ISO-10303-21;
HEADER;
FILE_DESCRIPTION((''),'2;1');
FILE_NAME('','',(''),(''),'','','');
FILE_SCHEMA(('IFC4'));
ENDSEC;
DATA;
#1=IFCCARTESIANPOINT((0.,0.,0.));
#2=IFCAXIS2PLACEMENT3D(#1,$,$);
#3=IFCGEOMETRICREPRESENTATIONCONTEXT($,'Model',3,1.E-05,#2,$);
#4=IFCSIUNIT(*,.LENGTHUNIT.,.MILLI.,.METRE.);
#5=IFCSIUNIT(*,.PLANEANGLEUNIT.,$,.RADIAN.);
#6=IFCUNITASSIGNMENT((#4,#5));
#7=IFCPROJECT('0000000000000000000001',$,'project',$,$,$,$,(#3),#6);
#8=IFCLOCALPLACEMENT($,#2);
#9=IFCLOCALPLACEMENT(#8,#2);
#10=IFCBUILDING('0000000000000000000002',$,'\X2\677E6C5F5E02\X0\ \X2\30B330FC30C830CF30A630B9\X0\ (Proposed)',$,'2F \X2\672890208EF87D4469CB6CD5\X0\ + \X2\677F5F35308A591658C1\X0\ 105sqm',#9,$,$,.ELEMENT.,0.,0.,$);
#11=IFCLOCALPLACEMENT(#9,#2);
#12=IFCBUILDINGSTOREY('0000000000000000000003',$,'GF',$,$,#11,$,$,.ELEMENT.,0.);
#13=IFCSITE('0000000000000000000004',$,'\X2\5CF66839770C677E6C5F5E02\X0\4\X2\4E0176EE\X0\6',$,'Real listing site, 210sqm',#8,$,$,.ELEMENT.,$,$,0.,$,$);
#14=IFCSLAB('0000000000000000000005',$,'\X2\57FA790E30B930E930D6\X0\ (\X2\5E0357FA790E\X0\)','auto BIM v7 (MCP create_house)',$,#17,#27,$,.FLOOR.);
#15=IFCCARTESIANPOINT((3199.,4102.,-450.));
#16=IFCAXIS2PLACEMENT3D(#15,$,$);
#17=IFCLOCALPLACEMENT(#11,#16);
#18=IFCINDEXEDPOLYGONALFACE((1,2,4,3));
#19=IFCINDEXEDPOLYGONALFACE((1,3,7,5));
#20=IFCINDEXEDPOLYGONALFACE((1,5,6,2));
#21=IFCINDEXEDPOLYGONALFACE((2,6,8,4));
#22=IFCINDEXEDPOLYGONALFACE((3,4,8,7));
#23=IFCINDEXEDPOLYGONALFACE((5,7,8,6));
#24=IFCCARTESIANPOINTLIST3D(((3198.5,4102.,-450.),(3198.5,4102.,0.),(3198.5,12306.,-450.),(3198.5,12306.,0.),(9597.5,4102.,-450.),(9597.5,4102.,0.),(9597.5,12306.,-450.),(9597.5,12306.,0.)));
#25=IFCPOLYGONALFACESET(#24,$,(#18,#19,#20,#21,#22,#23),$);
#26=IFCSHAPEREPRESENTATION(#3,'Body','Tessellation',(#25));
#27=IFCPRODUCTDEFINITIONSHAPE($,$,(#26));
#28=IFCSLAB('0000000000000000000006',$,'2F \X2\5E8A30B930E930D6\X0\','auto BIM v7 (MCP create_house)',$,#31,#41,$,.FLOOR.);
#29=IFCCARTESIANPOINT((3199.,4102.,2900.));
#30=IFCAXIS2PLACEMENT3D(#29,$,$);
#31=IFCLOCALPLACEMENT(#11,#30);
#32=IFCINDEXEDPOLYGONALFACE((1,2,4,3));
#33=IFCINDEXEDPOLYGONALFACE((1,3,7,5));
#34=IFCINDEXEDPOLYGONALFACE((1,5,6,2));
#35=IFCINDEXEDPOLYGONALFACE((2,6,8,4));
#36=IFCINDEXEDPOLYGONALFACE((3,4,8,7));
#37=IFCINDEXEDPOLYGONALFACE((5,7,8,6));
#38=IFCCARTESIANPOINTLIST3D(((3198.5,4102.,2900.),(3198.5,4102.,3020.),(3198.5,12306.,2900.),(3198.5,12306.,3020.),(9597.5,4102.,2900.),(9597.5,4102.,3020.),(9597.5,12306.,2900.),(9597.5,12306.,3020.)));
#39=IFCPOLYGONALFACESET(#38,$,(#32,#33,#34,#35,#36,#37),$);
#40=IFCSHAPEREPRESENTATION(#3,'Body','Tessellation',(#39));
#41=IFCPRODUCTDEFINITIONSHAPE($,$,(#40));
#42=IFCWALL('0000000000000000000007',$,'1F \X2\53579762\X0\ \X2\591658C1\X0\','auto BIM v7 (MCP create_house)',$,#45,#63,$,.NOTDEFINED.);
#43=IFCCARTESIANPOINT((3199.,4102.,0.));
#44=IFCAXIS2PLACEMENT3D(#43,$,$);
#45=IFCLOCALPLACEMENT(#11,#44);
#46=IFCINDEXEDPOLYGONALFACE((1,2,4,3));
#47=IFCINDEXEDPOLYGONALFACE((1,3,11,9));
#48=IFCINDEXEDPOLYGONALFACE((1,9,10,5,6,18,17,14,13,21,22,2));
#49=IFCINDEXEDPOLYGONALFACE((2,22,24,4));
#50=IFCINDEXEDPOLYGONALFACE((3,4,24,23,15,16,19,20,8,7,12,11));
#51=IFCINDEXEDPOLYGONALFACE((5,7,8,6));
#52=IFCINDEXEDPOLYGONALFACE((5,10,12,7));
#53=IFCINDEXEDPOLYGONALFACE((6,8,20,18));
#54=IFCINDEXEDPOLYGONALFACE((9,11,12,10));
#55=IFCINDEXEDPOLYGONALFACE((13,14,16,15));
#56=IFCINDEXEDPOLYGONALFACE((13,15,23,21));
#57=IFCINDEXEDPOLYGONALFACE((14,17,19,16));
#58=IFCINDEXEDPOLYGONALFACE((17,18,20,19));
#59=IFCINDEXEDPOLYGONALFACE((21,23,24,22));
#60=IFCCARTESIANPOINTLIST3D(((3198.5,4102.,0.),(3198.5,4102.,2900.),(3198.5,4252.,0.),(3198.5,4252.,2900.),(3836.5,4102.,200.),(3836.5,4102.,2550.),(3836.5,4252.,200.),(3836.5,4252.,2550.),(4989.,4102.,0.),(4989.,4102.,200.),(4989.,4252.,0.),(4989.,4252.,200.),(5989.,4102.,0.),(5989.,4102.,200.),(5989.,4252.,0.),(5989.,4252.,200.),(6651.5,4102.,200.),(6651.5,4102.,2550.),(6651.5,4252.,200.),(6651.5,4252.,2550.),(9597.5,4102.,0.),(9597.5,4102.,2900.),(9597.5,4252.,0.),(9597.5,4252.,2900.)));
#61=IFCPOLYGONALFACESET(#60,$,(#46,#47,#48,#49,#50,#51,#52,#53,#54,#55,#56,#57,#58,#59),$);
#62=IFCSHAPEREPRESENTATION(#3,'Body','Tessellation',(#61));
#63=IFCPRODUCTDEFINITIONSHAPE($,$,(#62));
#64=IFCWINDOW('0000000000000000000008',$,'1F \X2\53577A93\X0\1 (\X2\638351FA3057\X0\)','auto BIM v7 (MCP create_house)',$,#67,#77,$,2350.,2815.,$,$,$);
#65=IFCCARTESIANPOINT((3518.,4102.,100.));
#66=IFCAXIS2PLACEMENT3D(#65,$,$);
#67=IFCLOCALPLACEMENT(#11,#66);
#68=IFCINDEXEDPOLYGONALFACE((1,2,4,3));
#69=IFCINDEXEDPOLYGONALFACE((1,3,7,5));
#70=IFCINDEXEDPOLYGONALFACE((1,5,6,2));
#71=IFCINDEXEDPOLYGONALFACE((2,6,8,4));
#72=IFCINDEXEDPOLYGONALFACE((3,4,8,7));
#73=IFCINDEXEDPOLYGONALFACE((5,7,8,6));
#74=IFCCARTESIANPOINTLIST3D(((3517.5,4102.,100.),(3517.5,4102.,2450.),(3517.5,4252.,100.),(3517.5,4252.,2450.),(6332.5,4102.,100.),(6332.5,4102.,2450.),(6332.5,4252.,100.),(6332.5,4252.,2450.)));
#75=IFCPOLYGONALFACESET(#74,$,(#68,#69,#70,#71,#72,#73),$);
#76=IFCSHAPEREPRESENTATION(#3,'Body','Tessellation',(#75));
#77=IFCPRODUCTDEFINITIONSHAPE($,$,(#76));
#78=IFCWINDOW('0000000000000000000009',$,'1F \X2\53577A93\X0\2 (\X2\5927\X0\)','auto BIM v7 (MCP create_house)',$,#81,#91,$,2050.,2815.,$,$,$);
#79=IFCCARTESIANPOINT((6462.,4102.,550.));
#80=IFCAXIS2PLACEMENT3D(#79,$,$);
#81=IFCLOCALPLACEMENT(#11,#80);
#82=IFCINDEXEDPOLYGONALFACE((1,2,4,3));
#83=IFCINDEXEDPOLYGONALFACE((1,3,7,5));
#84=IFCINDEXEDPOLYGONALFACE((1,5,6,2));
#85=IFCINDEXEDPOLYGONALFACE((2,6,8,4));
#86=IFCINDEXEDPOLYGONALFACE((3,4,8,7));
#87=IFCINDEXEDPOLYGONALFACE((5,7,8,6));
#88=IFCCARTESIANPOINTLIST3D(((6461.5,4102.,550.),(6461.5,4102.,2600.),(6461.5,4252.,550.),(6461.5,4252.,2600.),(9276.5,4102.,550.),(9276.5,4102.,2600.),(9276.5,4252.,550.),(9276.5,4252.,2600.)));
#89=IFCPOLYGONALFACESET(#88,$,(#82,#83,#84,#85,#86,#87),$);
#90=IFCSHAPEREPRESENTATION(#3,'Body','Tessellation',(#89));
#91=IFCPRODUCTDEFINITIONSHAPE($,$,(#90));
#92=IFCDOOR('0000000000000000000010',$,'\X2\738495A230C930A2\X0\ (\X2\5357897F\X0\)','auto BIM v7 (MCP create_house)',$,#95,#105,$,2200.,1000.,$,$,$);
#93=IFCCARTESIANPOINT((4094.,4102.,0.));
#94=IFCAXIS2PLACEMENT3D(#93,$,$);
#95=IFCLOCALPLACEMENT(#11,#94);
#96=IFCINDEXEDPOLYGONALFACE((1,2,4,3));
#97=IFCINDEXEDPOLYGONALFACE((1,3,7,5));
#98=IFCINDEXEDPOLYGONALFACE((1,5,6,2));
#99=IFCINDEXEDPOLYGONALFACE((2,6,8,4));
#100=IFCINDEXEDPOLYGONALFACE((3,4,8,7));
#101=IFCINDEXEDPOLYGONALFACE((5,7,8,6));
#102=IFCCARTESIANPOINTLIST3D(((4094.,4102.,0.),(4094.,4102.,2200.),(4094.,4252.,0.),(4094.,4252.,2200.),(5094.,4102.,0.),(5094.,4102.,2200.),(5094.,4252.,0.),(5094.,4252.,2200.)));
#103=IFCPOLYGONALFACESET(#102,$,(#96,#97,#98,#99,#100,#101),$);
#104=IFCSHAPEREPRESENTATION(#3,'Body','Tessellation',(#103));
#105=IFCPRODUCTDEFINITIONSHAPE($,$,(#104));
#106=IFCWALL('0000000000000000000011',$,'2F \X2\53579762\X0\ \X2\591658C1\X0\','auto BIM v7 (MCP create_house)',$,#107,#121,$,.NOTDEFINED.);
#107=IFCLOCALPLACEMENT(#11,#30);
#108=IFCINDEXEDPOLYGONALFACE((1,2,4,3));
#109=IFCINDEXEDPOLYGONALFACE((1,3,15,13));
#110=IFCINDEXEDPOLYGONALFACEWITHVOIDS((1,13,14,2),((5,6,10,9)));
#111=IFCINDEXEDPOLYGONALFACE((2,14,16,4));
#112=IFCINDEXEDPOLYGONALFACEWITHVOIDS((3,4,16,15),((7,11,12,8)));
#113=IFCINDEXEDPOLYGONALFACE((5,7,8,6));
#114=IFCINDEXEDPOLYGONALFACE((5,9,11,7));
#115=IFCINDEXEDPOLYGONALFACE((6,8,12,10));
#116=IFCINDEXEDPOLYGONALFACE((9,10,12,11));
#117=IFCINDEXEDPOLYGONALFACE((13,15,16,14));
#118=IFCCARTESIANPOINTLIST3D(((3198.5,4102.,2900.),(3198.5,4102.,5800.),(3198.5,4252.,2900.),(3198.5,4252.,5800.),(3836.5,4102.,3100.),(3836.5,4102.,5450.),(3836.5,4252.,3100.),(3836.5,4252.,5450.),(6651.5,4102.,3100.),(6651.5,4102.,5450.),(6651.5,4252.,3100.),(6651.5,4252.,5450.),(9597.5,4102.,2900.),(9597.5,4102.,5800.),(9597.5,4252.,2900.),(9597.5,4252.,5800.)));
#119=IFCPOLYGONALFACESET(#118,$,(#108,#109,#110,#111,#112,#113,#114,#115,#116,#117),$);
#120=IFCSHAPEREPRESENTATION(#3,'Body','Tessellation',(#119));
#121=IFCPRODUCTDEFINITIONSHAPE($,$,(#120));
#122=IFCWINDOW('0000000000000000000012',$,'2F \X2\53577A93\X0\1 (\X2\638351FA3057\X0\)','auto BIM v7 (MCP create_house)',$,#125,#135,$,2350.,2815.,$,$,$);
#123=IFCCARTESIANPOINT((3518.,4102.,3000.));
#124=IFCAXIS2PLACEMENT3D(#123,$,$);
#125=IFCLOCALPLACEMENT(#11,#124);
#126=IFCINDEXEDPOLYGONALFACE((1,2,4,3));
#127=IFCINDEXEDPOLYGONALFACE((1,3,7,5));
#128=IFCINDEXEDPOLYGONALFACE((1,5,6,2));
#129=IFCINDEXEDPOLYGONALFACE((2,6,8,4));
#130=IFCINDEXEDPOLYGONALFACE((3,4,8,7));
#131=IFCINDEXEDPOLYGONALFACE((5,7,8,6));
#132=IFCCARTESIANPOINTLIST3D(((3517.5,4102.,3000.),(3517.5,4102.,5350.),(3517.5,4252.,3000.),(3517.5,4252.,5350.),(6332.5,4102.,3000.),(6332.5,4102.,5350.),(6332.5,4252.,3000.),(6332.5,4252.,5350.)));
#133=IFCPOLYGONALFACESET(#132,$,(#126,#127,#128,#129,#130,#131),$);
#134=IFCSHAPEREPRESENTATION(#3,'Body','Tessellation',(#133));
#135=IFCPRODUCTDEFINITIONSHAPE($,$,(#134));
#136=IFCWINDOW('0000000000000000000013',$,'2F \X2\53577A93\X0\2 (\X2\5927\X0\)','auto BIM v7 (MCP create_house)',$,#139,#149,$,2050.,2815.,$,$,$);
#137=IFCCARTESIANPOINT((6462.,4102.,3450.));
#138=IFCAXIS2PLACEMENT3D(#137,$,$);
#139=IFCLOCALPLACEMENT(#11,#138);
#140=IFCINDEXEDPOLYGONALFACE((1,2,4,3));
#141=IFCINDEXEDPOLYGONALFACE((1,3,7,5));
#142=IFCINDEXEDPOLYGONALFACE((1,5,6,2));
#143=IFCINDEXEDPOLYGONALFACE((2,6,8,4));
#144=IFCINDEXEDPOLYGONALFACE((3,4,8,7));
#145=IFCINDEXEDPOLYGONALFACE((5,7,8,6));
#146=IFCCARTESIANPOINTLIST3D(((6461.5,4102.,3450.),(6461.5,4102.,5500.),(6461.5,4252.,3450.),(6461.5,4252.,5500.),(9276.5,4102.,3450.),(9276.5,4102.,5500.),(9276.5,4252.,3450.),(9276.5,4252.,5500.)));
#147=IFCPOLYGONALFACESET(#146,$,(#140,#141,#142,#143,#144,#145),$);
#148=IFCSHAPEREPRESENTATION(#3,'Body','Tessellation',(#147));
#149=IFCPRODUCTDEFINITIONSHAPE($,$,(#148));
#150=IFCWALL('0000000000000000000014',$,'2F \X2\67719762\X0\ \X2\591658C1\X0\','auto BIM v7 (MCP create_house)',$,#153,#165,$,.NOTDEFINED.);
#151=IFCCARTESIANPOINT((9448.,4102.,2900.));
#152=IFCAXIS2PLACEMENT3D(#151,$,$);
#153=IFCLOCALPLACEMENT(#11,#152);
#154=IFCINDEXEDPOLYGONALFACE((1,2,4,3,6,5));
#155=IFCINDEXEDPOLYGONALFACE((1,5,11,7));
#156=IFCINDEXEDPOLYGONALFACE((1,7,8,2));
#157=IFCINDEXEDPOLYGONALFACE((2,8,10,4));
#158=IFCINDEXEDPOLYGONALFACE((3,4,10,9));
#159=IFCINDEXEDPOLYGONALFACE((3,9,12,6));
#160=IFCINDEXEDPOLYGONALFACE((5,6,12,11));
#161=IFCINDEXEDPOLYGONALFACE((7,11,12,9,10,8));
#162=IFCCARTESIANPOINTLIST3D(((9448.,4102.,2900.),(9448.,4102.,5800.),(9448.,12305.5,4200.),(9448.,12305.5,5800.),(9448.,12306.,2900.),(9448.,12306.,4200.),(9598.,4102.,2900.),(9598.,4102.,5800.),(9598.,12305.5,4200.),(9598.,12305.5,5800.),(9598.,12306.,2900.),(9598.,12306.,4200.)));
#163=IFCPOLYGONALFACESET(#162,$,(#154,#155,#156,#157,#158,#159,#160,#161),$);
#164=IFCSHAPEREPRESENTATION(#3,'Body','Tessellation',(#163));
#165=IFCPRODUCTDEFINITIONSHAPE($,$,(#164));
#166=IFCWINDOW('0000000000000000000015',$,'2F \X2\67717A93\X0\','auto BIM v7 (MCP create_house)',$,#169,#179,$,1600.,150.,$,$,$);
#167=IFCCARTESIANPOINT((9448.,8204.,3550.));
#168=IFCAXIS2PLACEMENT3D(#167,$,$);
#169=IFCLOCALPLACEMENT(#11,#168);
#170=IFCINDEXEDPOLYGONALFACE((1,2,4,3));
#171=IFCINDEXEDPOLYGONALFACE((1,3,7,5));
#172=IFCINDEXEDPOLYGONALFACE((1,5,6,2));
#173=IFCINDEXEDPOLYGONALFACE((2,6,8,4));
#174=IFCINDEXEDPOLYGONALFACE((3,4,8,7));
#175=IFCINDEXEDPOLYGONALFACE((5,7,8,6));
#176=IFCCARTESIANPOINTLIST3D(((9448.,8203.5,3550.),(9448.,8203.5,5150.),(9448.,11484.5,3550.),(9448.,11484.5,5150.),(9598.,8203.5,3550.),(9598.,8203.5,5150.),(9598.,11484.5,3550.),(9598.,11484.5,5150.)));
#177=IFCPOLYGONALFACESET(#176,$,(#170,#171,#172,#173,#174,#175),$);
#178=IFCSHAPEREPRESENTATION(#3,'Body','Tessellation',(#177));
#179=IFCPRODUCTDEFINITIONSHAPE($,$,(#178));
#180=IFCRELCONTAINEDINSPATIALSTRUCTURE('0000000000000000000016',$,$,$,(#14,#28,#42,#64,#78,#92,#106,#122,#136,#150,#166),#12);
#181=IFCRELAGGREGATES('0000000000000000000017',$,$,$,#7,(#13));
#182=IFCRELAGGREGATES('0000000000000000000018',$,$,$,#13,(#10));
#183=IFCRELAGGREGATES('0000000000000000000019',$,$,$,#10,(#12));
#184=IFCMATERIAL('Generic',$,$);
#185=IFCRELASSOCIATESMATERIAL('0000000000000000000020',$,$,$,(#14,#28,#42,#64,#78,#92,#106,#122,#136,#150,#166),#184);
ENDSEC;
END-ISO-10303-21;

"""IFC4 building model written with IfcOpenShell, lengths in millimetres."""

from ifc_helpers import new_model, si_unit, frame, frame_2d, origin, place, context, project, spatial, rectangle, extrude, material, element, fill, save


model = new_model("IFC4")

# Units and contexts
model_context = context("Model", 3, precision=1e-05, world=origin())
ifc_project = project(units=[si_unit("LENGTHUNIT", "METRE", prefix="MILLI"), si_unit("PLANEANGLEUNIT", "RADIAN")], contexts=[model_context])

# Site, building, storey
site_placement = place(None, origin())
site = spatial("IfcSite", under=ifc_project, at=site_placement, Name="島根県松江市4丁目6", ObjectType="Real listing site, 210sqm", CompositionType="ELEMENT", RefElevation=0.0)
building_placement = place(site_placement, origin())
building = spatial("IfcBuilding", under=site, at=building_placement, Name="松江市 コートハウス (Proposed)", ObjectType="2F 木造軸組構法 + 板張り外壁 105sqm", CompositionType="ELEMENT", ElevationOfRefHeight=0.0, ElevationOfTerrain=0.0)
storey_placement = place(building_placement, origin())
storey = spatial("IfcBuildingStorey", under=building, at=storey_placement, Name="GF", CompositionType="ELEMENT", Elevation=0.0)

# Slabs
ifc_material = material(Name="Generic")
slab_1_placement = place(storey_placement, frame((3199.0, 4102.0, -450.0)))
element("IfcSlab", 1, at=slab_1_placement, inside=storey, material=ifc_material, Name="基礎スラブ (布基礎)", Description="auto BIM v7 (MCP create_house)", PredefinedType="FLOOR", context=model_context, shape_type="SweptSolid", body=[
    extrude(rectangle(XDim=6399.0, YDim=8204.0, at=frame_2d((3199.0, 4102.0))), frame((3199.0, 4102.0, -450.0)), (0.0, 0.0, 1.0), 450.0),
])
slab_2_placement = place(storey_placement, frame((3199.0, 4102.0, 2900.0)))
element("IfcSlab", 2, at=slab_2_placement, inside=storey, material=ifc_material, Name="2F 床スラブ", Description="auto BIM v7 (MCP create_house)", PredefinedType="FLOOR", context=model_context, shape_type="SweptSolid", body=[
    extrude(rectangle(XDim=6399.0, YDim=8204.0, at=frame_2d((3199.0, 4102.0))), frame((3199.0, 4102.0, 2900.0)), (0.0, 0.0, 1.0), 120.0),
])

# Wall, openings, windows, door
wall_1_placement = place(storey_placement, frame((3199.0, 4102.0, 0.0)))
wall_1 = element("IfcWall", 3, at=wall_1_placement, inside=storey, material=ifc_material, Name="1F 南面 外壁", Description="auto BIM v7 (MCP create_house)", PredefinedType="NOTDEFINED", context=model_context, shape_type="SweptSolid", body=[
    extrude(rectangle(XDim=6399.0, YDim=150.0, at=frame_2d((3199.0, 75.0))), frame((3199.0, 4102.0, 0.0)), (0.0, 0.0, 1.0), 2900.0),
])
opening_1_placement = place(storey_placement, frame((3518.0, 4102.0, 100.0)))
opening_1 = element("IfcOpeningElement", 4, at=opening_1_placement, cuts=wall_1, PredefinedType="NOTDEFINED", context=model_context, shape_type="SweptSolid", body=[
    extrude(rectangle(XDim=2815.0, YDim=150.0, at=frame_2d((1407.0, 75.0))), frame((3518.0, 4102.0, 100.0)), (0.0, 0.0, 1.0), 2350.0),
])
opening_2_placement = place(storey_placement, frame((6462.0, 4102.0, 550.0)))
opening_2 = element("IfcOpeningElement", 5, at=opening_2_placement, cuts=wall_1, PredefinedType="NOTDEFINED", context=model_context, shape_type="SweptSolid", body=[
    extrude(rectangle(XDim=2815.0, YDim=150.0, at=frame_2d((1407.0, 75.0))), frame((6462.0, 4102.0, 550.0)), (0.0, 0.0, 1.0), 2050.0),
])
opening_3_placement = place(storey_placement, frame((4094.0, 4102.0, 0.0)))
opening_3 = element("IfcOpeningElement", 6, at=opening_3_placement, cuts=wall_1, PredefinedType="NOTDEFINED", context=model_context, shape_type="SweptSolid", body=[
    extrude(rectangle(XDim=1000.0, YDim=150.0, at=frame_2d((500.0, 75.0))), frame((4094.0, 4102.0, 0.0)), (0.0, 0.0, 1.0), 2200.0),
])
window_1_placement = place(storey_placement, frame((3518.0, 4102.0, 100.0)))
window_1 = element("IfcWindow", 7, at=window_1_placement, inside=storey, material=ifc_material, Name="1F 南窓1 (掃出し)", Description="auto BIM v7 (MCP create_house)", OverallHeight=2350.0, OverallWidth=2815.0, context=model_context, shape_type="SweptSolid", body=[
    extrude(rectangle(XDim=2815.0, YDim=150.0, at=frame_2d((1407.0, 75.0))), frame((3518.0, 4102.0, 100.0)), (0.0, 0.0, 1.0), 2350.0),
])
fill(opening_1, window_1)
window_2_placement = place(storey_placement, frame((6462.0, 4102.0, 550.0)))
window_2 = element("IfcWindow", 8, at=window_2_placement, inside=storey, material=ifc_material, Name="1F 南窓2 (大)", Description="auto BIM v7 (MCP create_house)", OverallHeight=2050.0, OverallWidth=2815.0, context=model_context, shape_type="SweptSolid", body=[
    extrude(rectangle(XDim=2815.0, YDim=150.0, at=frame_2d((1407.0, 75.0))), frame((6462.0, 4102.0, 550.0)), (0.0, 0.0, 1.0), 2050.0),
])
fill(opening_2, window_2)
door_placement = place(storey_placement, frame((4094.0, 4102.0, 0.0)))
door = element("IfcDoor", 9, at=door_placement, inside=storey, material=ifc_material, Name="玄関ドア (南西)", Description="auto BIM v7 (MCP create_house)", OverallHeight=2200.0, OverallWidth=1000.0, context=model_context, shape_type="SweptSolid", body=[
    extrude(rectangle(XDim=1000.0, YDim=150.0, at=frame_2d((500.0, 75.0))), frame((4094.0, 4102.0, 0.0)), (0.0, 0.0, 1.0), 2200.0),
])
fill(opening_3, door)

# Wall, openings, windows
wall_2_placement = place(storey_placement, frame((3199.0, 4102.0, 2900.0)))
wall_2 = element("IfcWall", 10, at=wall_2_placement, inside=storey, material=ifc_material, Name="2F 南面 外壁", Description="auto BIM v7 (MCP create_house)", PredefinedType="NOTDEFINED", context=model_context, shape_type="SweptSolid", body=[
    extrude(rectangle(XDim=6399.0, YDim=150.0, at=frame_2d((3199.0, 75.0))), frame((3199.0, 4102.0, 2900.0)), (0.0, 0.0, 1.0), 2900.0),
])
opening_4_placement = place(storey_placement, frame((3518.0, 4102.0, 3000.0)))
opening_4 = element("IfcOpeningElement", 11, at=opening_4_placement, cuts=wall_2, PredefinedType="NOTDEFINED", context=model_context, shape_type="SweptSolid", body=[
    extrude(rectangle(XDim=2815.0, YDim=150.0, at=frame_2d((1407.0, 75.0))), frame((3518.0, 4102.0, 3000.0)), (0.0, 0.0, 1.0), 2350.0),
])
opening_5_placement = place(storey_placement, frame((6462.0, 4102.0, 3450.0)))
opening_5 = element("IfcOpeningElement", 12, at=opening_5_placement, cuts=wall_2, PredefinedType="NOTDEFINED", context=model_context, shape_type="SweptSolid", body=[
    extrude(rectangle(XDim=2815.0, YDim=150.0, at=frame_2d((1407.0, 75.0))), frame((6462.0, 4102.0, 3450.0)), (0.0, 0.0, 1.0), 2050.0),
])
window_3_placement = place(storey_placement, frame((3518.0, 4102.0, 3000.0)))
window_3 = element("IfcWindow", 13, at=window_3_placement, inside=storey, material=ifc_material, Name="2F 南窓1 (掃出し)", Description="auto BIM v7 (MCP create_house)", OverallHeight=2350.0, OverallWidth=2815.0, context=model_context, shape_type="SweptSolid", body=[
    extrude(rectangle(XDim=2815.0, YDim=150.0, at=frame_2d((1407.0, 75.0))), frame((3518.0, 4102.0, 3000.0)), (0.0, 0.0, 1.0), 2350.0),
])
fill(opening_4, window_3)
window_4_placement = place(storey_placement, frame((6462.0, 4102.0, 3450.0)))
window_4 = element("IfcWindow", 14, at=window_4_placement, inside=storey, material=ifc_material, Name="2F 南窓2 (大)", Description="auto BIM v7 (MCP create_house)", OverallHeight=2050.0, OverallWidth=2815.0, context=model_context, shape_type="SweptSolid", body=[
    extrude(rectangle(XDim=2815.0, YDim=150.0, at=frame_2d((1407.0, 75.0))), frame((6462.0, 4102.0, 3450.0)), (0.0, 0.0, 1.0), 2050.0),
])
fill(opening_5, window_4)

# Wall, opening, window
wall_3_placement = place(storey_placement, frame((9448.0, 4102.0, 2900.0)))
wall_3 = element("IfcWall", 15, at=wall_3_placement, inside=storey, material=ifc_material, Name="2F 東面 外壁", Description="auto BIM v7 (MCP create_house)", PredefinedType="NOTDEFINED", context=model_context, shape_type="SweptSolid", body=[
    extrude(rectangle(XDim=150.0, YDim=8204.0, at=frame_2d((75.0, 4102.0))), frame((9448.0, 4102.0, 2900.0)), (0.0, 0.0, 1.0), 2900.0),
])
opening_6_placement = place(storey_placement, frame((9448.0, 8204.0, 3550.0)))
opening_6 = element("IfcOpeningElement", 16, at=opening_6_placement, cuts=wall_3, PredefinedType="NOTDEFINED", context=model_context, shape_type="SweptSolid", body=[
    extrude(rectangle(XDim=150.0, YDim=3281.0, at=frame_2d((75.0, 1640.0))), frame((9448.0, 8204.0, 3550.0)), (0.0, 0.0, 1.0), 1600.0),
])
window_5_placement = place(storey_placement, frame((9448.0, 8204.0, 3550.0)))
window_5 = element("IfcWindow", 17, at=window_5_placement, inside=storey, material=ifc_material, Name="2F 東窓", Description="auto BIM v7 (MCP create_house)", OverallHeight=1600.0, OverallWidth=150.0, context=model_context, shape_type="SweptSolid", body=[
    extrude(rectangle(XDim=150.0, YDim=3281.0, at=frame_2d((75.0, 1640.0))), frame((9448.0, 8204.0, 3550.0)), (0.0, 0.0, 1.0), 1600.0),
])
fill(opening_6, window_5)

save(model, "model.ifc")
